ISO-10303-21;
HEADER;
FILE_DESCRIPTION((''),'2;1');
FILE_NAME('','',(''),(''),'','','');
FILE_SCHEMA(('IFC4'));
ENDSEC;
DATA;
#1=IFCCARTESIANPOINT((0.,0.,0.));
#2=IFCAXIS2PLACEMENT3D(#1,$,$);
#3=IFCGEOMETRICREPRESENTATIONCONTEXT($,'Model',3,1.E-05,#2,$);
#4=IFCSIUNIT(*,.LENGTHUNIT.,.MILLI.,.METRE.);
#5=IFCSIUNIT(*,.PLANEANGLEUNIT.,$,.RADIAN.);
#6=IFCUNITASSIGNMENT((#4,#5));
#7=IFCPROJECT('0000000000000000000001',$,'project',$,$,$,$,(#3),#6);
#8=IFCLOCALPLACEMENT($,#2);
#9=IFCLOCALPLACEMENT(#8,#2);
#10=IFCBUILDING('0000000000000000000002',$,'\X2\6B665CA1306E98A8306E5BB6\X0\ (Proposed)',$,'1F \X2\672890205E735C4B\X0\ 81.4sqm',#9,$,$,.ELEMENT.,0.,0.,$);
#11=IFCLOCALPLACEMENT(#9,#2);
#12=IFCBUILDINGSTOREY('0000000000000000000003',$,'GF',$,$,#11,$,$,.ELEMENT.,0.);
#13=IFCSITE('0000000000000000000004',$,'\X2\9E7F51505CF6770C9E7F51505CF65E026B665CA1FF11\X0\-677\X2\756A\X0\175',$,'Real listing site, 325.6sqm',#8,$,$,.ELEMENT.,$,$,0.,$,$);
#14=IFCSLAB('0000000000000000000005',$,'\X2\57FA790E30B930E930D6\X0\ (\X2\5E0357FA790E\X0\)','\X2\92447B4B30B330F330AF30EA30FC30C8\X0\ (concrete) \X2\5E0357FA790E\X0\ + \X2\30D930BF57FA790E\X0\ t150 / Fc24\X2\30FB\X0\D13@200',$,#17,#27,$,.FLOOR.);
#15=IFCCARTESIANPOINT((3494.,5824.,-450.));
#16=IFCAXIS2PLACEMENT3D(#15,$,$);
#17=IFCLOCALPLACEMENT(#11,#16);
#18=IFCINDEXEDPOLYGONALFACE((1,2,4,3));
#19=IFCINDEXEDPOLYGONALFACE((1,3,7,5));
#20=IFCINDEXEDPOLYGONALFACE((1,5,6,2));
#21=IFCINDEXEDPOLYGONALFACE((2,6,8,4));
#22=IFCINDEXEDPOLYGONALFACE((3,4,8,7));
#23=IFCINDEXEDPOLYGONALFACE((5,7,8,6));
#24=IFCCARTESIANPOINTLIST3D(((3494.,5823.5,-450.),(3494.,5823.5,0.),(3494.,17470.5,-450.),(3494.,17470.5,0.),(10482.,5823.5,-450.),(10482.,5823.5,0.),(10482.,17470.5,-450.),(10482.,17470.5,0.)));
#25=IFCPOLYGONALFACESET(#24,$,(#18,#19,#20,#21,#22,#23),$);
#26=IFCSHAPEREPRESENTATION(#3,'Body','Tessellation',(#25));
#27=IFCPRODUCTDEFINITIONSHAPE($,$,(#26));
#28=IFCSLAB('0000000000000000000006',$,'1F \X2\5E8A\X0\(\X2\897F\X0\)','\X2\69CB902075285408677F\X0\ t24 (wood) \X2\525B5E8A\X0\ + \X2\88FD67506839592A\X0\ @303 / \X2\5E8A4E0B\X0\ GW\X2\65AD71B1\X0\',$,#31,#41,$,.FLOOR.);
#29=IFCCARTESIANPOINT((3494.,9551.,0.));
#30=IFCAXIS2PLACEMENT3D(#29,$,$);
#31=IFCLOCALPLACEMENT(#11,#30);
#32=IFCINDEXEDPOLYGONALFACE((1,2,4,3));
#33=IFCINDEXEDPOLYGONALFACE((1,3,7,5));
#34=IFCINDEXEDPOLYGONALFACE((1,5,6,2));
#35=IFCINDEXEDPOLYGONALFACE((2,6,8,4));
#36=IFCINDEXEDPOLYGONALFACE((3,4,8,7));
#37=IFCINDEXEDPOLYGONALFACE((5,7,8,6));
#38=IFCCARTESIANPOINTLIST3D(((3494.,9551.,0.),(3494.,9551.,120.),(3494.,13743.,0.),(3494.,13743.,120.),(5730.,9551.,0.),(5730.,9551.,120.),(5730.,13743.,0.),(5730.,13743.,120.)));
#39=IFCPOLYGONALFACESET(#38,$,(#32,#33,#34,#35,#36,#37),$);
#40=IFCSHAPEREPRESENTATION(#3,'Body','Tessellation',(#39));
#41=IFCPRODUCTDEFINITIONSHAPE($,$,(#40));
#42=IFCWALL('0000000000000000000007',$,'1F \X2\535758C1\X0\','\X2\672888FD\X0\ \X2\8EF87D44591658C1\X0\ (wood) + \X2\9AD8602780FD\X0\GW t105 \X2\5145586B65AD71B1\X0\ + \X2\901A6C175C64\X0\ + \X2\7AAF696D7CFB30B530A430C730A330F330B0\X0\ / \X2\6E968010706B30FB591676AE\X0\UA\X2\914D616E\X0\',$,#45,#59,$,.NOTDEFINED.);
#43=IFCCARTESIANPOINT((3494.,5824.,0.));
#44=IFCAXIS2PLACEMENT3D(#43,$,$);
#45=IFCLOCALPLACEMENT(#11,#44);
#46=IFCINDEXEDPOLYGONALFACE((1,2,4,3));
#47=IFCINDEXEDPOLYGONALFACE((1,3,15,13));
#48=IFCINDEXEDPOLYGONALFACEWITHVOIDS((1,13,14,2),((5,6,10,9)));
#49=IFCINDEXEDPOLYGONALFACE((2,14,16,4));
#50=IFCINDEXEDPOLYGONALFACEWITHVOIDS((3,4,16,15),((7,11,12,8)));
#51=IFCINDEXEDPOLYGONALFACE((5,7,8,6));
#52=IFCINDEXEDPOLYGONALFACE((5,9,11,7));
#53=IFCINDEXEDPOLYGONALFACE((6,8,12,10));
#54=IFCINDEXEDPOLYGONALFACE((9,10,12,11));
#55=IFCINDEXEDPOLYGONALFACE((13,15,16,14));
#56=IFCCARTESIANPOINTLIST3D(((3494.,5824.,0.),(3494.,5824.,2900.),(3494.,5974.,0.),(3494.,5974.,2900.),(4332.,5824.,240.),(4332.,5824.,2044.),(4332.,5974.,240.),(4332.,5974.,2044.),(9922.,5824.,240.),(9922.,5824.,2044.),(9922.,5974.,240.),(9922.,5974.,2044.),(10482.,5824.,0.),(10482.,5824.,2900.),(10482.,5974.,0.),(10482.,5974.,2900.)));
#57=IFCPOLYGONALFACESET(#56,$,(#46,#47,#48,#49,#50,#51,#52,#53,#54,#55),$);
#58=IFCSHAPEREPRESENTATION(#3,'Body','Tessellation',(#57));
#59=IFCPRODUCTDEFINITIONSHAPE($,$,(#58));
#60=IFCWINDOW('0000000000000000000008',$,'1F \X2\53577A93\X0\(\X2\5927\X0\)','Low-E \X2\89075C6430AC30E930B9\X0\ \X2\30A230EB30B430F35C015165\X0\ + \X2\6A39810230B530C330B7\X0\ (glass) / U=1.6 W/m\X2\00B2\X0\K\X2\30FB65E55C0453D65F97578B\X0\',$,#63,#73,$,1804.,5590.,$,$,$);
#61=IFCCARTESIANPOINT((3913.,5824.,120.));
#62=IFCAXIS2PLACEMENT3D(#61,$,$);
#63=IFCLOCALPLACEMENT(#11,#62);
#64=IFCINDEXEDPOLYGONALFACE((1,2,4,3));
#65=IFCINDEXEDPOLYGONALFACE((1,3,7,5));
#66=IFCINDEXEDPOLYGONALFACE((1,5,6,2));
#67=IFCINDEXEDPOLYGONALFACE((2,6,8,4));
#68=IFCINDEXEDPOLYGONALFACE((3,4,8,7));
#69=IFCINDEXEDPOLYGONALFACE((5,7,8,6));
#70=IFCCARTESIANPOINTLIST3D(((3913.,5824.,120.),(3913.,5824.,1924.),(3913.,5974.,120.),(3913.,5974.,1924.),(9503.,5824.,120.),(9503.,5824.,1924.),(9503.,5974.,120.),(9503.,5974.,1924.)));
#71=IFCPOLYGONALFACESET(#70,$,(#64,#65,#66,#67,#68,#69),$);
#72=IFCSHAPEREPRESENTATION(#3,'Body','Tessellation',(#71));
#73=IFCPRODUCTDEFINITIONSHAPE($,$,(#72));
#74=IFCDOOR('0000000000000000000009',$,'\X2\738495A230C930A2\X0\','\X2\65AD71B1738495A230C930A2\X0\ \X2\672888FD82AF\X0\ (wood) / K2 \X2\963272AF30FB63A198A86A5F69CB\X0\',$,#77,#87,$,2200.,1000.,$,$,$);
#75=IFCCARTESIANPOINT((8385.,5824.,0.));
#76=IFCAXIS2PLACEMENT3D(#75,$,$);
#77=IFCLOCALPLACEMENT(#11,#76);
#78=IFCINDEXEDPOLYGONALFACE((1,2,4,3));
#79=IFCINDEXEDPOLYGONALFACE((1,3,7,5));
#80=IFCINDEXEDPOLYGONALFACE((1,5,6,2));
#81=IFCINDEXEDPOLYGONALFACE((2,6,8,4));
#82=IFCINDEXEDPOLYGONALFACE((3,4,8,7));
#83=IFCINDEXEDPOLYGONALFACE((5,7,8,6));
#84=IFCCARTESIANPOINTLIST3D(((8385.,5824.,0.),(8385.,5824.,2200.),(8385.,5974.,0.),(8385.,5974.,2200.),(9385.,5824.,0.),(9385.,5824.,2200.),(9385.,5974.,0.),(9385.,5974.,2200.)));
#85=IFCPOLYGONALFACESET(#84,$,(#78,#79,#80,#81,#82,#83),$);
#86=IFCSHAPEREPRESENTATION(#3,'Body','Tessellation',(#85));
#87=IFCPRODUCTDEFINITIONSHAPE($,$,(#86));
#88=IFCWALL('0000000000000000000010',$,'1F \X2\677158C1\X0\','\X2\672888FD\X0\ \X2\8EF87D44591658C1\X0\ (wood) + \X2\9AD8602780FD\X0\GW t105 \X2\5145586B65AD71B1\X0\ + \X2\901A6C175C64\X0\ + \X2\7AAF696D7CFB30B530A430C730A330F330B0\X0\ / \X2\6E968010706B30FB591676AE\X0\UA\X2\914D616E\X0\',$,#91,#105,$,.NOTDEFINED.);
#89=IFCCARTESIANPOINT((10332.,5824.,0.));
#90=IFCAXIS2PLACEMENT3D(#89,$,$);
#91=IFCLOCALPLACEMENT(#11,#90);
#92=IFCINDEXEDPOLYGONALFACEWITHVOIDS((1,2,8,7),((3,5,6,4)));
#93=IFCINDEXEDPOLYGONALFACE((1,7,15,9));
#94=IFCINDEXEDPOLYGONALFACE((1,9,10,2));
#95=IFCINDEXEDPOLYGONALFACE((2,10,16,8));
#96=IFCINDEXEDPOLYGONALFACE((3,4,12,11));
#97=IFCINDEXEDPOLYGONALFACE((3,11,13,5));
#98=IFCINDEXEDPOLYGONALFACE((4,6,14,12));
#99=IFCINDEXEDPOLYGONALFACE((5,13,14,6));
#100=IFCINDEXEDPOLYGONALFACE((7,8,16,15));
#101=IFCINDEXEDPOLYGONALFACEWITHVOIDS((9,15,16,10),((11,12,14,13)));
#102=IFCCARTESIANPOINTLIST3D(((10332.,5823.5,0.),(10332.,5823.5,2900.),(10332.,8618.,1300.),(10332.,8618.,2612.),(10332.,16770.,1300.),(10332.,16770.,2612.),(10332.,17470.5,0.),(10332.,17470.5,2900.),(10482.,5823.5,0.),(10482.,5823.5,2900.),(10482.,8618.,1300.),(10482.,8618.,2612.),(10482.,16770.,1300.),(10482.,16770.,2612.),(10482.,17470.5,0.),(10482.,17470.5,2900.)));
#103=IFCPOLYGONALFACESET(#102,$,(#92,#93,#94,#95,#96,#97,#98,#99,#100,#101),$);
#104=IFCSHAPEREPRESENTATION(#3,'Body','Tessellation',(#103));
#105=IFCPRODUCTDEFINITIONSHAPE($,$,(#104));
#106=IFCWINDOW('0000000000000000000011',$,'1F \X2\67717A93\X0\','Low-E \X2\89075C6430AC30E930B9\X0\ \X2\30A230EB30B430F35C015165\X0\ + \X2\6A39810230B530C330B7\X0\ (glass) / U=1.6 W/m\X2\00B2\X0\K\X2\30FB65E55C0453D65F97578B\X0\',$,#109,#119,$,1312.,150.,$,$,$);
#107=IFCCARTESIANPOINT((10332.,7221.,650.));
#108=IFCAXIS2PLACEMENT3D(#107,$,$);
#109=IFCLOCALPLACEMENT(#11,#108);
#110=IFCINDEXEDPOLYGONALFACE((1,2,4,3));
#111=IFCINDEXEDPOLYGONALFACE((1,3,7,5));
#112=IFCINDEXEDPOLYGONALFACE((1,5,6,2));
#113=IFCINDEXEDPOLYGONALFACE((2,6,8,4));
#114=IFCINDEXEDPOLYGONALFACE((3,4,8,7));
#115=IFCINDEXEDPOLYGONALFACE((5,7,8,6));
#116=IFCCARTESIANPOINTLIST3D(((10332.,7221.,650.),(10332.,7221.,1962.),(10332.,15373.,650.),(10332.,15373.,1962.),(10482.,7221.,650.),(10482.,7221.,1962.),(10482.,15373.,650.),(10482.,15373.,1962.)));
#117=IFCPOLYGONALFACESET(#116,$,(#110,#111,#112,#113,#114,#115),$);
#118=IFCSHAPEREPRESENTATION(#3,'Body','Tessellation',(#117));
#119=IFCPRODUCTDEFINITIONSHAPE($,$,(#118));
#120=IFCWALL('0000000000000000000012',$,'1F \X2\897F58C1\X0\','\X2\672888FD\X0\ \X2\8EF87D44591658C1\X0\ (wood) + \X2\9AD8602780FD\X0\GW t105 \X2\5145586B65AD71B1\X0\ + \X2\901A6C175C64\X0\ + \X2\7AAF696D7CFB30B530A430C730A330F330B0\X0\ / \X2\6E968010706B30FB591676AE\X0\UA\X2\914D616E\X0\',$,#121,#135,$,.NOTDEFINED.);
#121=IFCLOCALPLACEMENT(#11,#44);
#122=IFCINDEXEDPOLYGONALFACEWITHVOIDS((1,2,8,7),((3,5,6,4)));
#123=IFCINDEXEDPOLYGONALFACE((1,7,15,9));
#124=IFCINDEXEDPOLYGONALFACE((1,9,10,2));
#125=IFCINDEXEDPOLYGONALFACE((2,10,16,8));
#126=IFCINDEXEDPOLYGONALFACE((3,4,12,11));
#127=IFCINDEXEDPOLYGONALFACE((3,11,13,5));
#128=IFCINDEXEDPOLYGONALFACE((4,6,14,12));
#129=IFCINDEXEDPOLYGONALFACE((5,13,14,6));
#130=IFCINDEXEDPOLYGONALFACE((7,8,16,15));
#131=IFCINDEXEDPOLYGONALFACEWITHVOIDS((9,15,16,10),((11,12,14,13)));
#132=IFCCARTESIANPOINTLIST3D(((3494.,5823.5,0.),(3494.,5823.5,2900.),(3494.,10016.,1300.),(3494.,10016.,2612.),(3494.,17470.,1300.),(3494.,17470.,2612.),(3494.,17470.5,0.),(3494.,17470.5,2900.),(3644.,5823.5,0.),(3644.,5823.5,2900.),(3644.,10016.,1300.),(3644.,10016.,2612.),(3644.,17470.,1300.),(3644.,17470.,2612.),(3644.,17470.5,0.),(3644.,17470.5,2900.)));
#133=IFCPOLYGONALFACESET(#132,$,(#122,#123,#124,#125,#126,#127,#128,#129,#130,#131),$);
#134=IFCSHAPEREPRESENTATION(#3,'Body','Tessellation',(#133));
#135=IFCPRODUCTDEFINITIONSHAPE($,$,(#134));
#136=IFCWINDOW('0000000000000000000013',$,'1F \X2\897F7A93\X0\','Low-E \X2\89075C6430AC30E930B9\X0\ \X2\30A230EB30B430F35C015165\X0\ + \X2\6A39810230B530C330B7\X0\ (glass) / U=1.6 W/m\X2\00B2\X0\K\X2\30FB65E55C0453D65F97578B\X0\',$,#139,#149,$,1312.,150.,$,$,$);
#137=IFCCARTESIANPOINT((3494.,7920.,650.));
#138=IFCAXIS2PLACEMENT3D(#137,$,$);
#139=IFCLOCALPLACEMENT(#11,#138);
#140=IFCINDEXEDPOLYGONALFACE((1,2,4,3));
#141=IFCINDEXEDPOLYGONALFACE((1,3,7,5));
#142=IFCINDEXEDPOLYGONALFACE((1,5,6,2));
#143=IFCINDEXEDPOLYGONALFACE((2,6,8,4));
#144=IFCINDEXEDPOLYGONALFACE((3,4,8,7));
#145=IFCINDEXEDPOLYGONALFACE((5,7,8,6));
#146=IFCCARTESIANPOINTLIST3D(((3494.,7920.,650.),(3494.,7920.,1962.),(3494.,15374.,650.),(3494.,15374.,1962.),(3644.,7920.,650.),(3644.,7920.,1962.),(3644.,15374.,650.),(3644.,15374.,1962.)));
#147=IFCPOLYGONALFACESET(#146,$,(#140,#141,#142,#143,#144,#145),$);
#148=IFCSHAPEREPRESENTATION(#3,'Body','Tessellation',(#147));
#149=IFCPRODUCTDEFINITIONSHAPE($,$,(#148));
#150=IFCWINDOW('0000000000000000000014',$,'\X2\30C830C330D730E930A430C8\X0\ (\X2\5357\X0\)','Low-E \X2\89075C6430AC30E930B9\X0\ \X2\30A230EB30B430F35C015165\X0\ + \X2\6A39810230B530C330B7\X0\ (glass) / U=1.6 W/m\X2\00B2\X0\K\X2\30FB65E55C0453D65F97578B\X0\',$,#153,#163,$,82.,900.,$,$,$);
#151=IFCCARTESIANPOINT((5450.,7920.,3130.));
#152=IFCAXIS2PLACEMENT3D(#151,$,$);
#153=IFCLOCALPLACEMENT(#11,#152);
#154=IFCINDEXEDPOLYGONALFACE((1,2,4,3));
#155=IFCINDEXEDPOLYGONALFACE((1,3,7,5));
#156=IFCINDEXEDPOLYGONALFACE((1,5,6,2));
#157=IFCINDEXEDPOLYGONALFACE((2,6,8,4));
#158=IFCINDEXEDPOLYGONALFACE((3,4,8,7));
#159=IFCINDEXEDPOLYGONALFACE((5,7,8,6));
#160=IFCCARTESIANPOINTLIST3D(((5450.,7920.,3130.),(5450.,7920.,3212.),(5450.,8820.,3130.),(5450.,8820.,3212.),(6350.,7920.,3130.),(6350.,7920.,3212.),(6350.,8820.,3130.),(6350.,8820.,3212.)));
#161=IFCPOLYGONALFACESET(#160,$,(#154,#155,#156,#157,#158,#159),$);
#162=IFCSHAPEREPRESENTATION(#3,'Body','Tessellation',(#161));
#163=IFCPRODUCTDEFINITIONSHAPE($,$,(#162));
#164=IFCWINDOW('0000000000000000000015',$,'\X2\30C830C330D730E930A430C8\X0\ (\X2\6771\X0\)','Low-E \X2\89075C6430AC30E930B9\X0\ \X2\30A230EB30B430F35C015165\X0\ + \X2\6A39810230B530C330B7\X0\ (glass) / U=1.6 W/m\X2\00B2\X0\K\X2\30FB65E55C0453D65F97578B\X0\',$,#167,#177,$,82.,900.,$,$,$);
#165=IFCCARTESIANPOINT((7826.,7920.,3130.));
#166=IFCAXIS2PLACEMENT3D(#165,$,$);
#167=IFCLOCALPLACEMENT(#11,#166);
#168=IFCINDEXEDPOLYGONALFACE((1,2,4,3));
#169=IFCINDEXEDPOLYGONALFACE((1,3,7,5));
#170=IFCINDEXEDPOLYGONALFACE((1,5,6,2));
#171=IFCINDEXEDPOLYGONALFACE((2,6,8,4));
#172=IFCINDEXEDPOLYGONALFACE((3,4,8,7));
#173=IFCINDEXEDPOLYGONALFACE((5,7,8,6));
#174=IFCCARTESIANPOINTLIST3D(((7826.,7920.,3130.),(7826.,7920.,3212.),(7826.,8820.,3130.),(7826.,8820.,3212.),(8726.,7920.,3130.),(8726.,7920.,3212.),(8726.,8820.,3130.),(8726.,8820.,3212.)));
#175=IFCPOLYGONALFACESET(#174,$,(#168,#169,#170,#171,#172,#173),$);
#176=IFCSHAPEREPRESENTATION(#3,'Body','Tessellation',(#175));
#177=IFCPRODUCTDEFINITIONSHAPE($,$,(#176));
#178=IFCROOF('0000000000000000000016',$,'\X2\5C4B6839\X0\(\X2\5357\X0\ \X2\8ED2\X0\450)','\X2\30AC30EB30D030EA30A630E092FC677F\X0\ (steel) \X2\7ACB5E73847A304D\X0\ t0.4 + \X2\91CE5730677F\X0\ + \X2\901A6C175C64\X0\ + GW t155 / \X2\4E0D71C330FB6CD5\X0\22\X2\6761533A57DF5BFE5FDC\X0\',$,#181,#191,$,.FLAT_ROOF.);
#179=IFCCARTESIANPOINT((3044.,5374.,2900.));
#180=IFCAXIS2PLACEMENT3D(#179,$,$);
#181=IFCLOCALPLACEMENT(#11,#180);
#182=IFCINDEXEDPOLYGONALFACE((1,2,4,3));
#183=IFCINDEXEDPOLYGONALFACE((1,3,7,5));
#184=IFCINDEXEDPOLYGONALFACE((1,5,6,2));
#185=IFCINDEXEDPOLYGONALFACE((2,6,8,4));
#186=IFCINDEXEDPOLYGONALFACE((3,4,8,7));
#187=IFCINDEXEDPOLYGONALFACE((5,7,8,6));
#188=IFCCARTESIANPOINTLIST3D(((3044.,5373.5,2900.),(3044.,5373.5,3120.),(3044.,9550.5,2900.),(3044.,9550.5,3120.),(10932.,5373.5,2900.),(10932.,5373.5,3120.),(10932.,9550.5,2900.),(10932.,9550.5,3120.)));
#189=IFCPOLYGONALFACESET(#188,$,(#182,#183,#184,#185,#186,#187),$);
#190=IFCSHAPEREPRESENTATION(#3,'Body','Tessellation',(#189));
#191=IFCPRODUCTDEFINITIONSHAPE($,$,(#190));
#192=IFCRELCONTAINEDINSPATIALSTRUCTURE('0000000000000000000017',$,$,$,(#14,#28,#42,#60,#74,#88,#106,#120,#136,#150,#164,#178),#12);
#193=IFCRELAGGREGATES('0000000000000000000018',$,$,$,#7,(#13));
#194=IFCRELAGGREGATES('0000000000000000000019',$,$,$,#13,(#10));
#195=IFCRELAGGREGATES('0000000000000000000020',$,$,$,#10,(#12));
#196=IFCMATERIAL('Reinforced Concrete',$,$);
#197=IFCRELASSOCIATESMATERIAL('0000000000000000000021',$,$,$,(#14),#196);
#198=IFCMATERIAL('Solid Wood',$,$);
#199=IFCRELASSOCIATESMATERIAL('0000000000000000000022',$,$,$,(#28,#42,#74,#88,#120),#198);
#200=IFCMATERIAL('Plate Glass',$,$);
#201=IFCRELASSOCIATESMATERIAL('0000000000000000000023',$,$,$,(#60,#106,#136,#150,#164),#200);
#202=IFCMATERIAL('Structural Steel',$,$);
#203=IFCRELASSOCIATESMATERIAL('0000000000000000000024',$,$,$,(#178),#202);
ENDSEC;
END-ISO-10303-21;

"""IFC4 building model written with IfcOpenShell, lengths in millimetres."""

from ifc_helpers import new_model, si_unit, frame, frame_2d, origin, place, context, project, spatial, rectangle, extrude, material, element, fill, save


model = new_model("IFC4")

# Units and contexts
model_context = context("Model", 3, precision=1e-05, world=origin())
ifc_project = project(units=[si_unit("LENGTHUNIT", "METRE", prefix="MILLI"), si_unit("PLANEANGLEUNIT", "RADIAN")], contexts=[model_context])

# Site, building, storey
site_placement = place(None, origin())
site = spatial("IfcSite", under=ifc_project, at=site_placement, Name="鹿児島県鹿児島市武岡１-677番175", ObjectType="Real listing site, 325.6sqm", CompositionType="ELEMENT", RefElevation=0.0)
building_placement = place(site_placement, origin())
building = spatial("IfcBuilding", under=site, at=building_placement, Name="武岡の風の家 (Proposed)", ObjectType="1F 木造平屋 81.4sqm", CompositionType="ELEMENT", ElevationOfRefHeight=0.0, ElevationOfTerrain=0.0)
storey_placement = place(building_placement, origin())
storey = spatial("IfcBuildingStorey", under=building, at=storey_placement, Name="GF", CompositionType="ELEMENT", Elevation=0.0)

# Slabs
ifc_material_1 = material(Name="Reinforced Concrete")
slab_1_placement = place(storey_placement, frame((3494.0, 5824.0, -450.0)))
element("IfcSlab", 1, at=slab_1_placement, inside=storey, material=ifc_material_1, Name="基礎スラブ (布基礎)", Description="鉄筋コンクリート (concrete) 布基礎 + ベタ基礎 t150 / Fc24・D13@200", PredefinedType="FLOOR", context=model_context, shape_type="SweptSolid", body=[
    extrude(rectangle(XDim=6988.0, YDim=11647.0, at=frame_2d((3494.0, 5823.0))), frame((3494.0, 5824.0, -450.0)), (0.0, 0.0, 1.0), 450.0),
])
ifc_material_2 = material(Name="Solid Wood")
slab_2_placement = place(storey_placement, frame((3494.0, 9551.0, 0.0)))
element("IfcSlab", 2, at=slab_2_placement, inside=storey, material=ifc_material_2, Name="1F 床(西)", Description="構造用合板 t24 (wood) 剛床 + 製材根太 @303 / 床下 GW断熱", PredefinedType="FLOOR", context=model_context, shape_type="SweptSolid", body=[
    extrude(rectangle(XDim=2236.0, YDim=4192.0, at=frame_2d((1118.0, 2096.0))), frame((3494.0, 9551.0, 0.0)), (0.0, 0.0, 1.0), 120.0),
])

# Wall, openings, window, door
wall_1_placement = place(storey_placement, frame((3494.0, 5824.0, 0.0)))
wall_1 = element("IfcWall", 3, at=wall_1_placement, inside=storey, material=ifc_material_2, Name="1F 南壁", Description="木製 軸組外壁 (wood) + 高性能GW t105 充填断熱 + 通気層 + 窯業系サイディング / 準耐火・外皮UA配慮", PredefinedType="NOTDEFINED", context=model_context, shape_type="SweptSolid", body=[
    extrude(rectangle(XDim=6988.0, YDim=150.0, at=frame_2d((3494.0, 75.0))), frame((3494.0, 5824.0, 0.0)), (0.0, 0.0, 1.0), 2900.0),
])
opening_1_placement = place(storey_placement, frame((3913.0, 5824.0, 120.0)))
opening_1 = element("IfcOpeningElement", 4, at=opening_1_placement, cuts=wall_1, PredefinedType="NOTDEFINED", context=model_context, shape_type="SweptSolid", body=[
    extrude(rectangle(XDim=5590.0, YDim=150.0, at=frame_2d((2795.0, 75.0))), frame((3913.0, 5824.0, 120.0)), (0.0, 0.0, 1.0), 1804.0),
])
opening_2_placement = place(storey_placement, frame((8385.0, 5824.0, 0.0)))
opening_2 = element("IfcOpeningElement", 5, at=opening_2_placement, cuts=wall_1, PredefinedType="NOTDEFINED", context=model_context, shape_type="SweptSolid", body=[
    extrude(rectangle(XDim=1000.0, YDim=150.0, at=frame_2d((500.0, 75.0))), frame((8385.0, 5824.0, 0.0)), (0.0, 0.0, 1.0), 2200.0),
])
ifc_material_3 = material(Name="Plate Glass")
window_1_placement = place(storey_placement, frame((3913.0, 5824.0, 120.0)))
window_1 = element("IfcWindow", 6, at=window_1_placement, inside=storey, material=ifc_material_3, Name="1F 南窓(大)", Description="Low-E 複層ガラス アルゴン封入 + 樹脂サッシ (glass) / U=1.6 W/m²K・日射取得型", OverallHeight=1804.0, OverallWidth=5590.0, context=model_context, shape_type="SweptSolid", body=[
    extrude(rectangle(XDim=5590.0, YDim=150.0, at=frame_2d((2795.0, 75.0))), frame((3913.0, 5824.0, 120.0)), (0.0, 0.0, 1.0), 1804.0),
])
fill(opening_1, window_1)
door_placement = place(storey_placement, frame((8385.0, 5824.0, 0.0)))
door = element("IfcDoor", 7, at=door_placement, inside=storey, material=ifc_material_2, Name="玄関ドア", Description="断熱玄関ドア 木製芯 (wood) / K2 防犯・採風機構", OverallHeight=2200.0, OverallWidth=1000.0, context=model_context, shape_type="SweptSolid", body=[
    extrude(rectangle(XDim=1000.0, YDim=150.0, at=frame_2d((500.0, 75.0))), frame((8385.0, 5824.0, 0.0)), (0.0, 0.0, 1.0), 2200.0),
])
fill(opening_2, door)

# Walls, openings, windows
wall_2_placement = place(storey_placement, frame((10332.0, 5824.0, 0.0)))
wall_2 = element("IfcWall", 8, at=wall_2_placement, inside=storey, material=ifc_material_2, Name="1F 東壁", Description="木製 軸組外壁 (wood) + 高性能GW t105 充填断熱 + 通気層 + 窯業系サイディング / 準耐火・外皮UA配慮", PredefinedType="NOTDEFINED", context=model_context, shape_type="SweptSolid", body=[
    extrude(rectangle(XDim=150.0, YDim=11647.0, at=frame_2d((75.0, 5823.0))), frame((10332.0, 5824.0, 0.0)), (0.0, 0.0, 1.0), 2900.0),
])
opening_3_placement = place(storey_placement, frame((10332.0, 7221.0, 650.0)))
opening_3 = element("IfcOpeningElement", 9, at=opening_3_placement, cuts=wall_2, PredefinedType="NOTDEFINED", context=model_context, shape_type="SweptSolid", body=[
    extrude(rectangle(XDim=150.0, YDim=8152.0, at=frame_2d((75.0, 4076.0))), frame((10332.0, 7221.0, 650.0)), (0.0, 0.0, 1.0), 1312.0),
])
window_2_placement = place(storey_placement, frame((10332.0, 7221.0, 650.0)))
window_2 = element("IfcWindow", 10, at=window_2_placement, inside=storey, material=ifc_material_3, Name="1F 東窓", Description="Low-E 複層ガラス アルゴン封入 + 樹脂サッシ (glass) / U=1.6 W/m²K・日射取得型", OverallHeight=1312.0, OverallWidth=150.0, context=model_context, shape_type="SweptSolid", body=[
    extrude(rectangle(XDim=150.0, YDim=8152.0, at=frame_2d((75.0, 4076.0))), frame((10332.0, 7221.0, 650.0)), (0.0, 0.0, 1.0), 1312.0),
])
fill(opening_3, window_2)
wall_3_placement = place(storey_placement, frame((3494.0, 5824.0, 0.0)))
wall_3 = element("IfcWall", 11, at=wall_3_placement, inside=storey, material=ifc_material_2, Name="1F 西壁", Description="木製 軸組外壁 (wood) + 高性能GW t105 充填断熱 + 通気層 + 窯業系サイディング / 準耐火・外皮UA配慮", PredefinedType="NOTDEFINED", context=model_context, shape_type="SweptSolid", body=[
    extrude(rectangle(XDim=150.0, YDim=11647.0, at=frame_2d((75.0, 5823.0))), frame((3494.0, 5824.0, 0.0)), (0.0, 0.0, 1.0), 2900.0),
])
opening_4_placement = place(storey_placement, frame((3494.0, 7920.0, 650.0)))
opening_4 = element("IfcOpeningElement", 12, at=opening_4_placement, cuts=wall_3, PredefinedType="NOTDEFINED", context=model_context, shape_type="SweptSolid", body=[
    extrude(rectangle(XDim=150.0, YDim=7454.0, at=frame_2d((75.0, 3727.0))), frame((3494.0, 7920.0, 650.0)), (0.0, 0.0, 1.0), 1312.0),
])
window_3_placement = place(storey_placement, frame((3494.0, 7920.0, 650.0)))
window_3 = element("IfcWindow", 13, at=window_3_placement, inside=storey, material=ifc_material_3, Name="1F 西窓", Description="Low-E 複層ガラス アルゴン封入 + 樹脂サッシ (glass) / U=1.6 W/m²K・日射取得型", OverallHeight=1312.0, OverallWidth=150.0, context=model_context, shape_type="SweptSolid", body=[
    extrude(rectangle(XDim=150.0, YDim=7454.0, at=frame_2d((75.0, 3727.0))), frame((3494.0, 7920.0, 650.0)), (0.0, 0.0, 1.0), 1312.0),
])
fill(opening_4, window_3)

# Windows
window_4_placement = place(storey_placement, frame((5450.0, 7920.0, 3130.0)))
element("IfcWindow", 14, at=window_4_placement, inside=storey, material=ifc_material_3, Name="トップライト (南)", Description="Low-E 複層ガラス アルゴン封入 + 樹脂サッシ (glass) / U=1.6 W/m²K・日射取得型", OverallHeight=82.0, OverallWidth=900.0, context=model_context, shape_type="SweptSolid", body=[
    extrude(rectangle(XDim=900.0, YDim=900.0, at=frame_2d((450.0, 450.0))), frame((5450.0, 7920.0, 3130.0)), (0.0, 0.0, 1.0), 82.0),
])
window_5_placement = place(storey_placement, frame((7826.0, 7920.0, 3130.0)))
element("IfcWindow", 15, at=window_5_placement, inside=storey, material=ifc_material_3, Name="トップライト (東)", Description="Low-E 複層ガラス アルゴン封入 + 樹脂サッシ (glass) / U=1.6 W/m²K・日射取得型", OverallHeight=82.0, OverallWidth=900.0, context=model_context, shape_type="SweptSolid", body=[
    extrude(rectangle(XDim=900.0, YDim=900.0, at=frame_2d((450.0, 450.0))), frame((7826.0, 7920.0, 3130.0)), (0.0, 0.0, 1.0), 82.0),
])

# Roof
ifc_material_4 = material(Name="Structural Steel")
roof_placement = place(storey_placement, frame((3044.0, 5374.0, 2900.0)))
element("IfcRoof", 16, at=roof_placement, inside=storey, material=ifc_material_4, Name="屋根(南 軒450)", Description="ガルバリウム鋼板 (steel) 立平葺き t0.4 + 野地板 + 通気層 + GW t155 / 不燃・法22条区域対応", PredefinedType="FLAT_ROOF", context=model_context, shape_type="SweptSolid", body=[
    extrude(rectangle(XDim=7888.0, YDim=4177.0, at=frame_2d((3944.0, 2088.0))), frame((3044.0, 5374.0, 2900.0)), (0.0, 0.0, 1.0), 220.0),
])

save(model, "model.ifc")
